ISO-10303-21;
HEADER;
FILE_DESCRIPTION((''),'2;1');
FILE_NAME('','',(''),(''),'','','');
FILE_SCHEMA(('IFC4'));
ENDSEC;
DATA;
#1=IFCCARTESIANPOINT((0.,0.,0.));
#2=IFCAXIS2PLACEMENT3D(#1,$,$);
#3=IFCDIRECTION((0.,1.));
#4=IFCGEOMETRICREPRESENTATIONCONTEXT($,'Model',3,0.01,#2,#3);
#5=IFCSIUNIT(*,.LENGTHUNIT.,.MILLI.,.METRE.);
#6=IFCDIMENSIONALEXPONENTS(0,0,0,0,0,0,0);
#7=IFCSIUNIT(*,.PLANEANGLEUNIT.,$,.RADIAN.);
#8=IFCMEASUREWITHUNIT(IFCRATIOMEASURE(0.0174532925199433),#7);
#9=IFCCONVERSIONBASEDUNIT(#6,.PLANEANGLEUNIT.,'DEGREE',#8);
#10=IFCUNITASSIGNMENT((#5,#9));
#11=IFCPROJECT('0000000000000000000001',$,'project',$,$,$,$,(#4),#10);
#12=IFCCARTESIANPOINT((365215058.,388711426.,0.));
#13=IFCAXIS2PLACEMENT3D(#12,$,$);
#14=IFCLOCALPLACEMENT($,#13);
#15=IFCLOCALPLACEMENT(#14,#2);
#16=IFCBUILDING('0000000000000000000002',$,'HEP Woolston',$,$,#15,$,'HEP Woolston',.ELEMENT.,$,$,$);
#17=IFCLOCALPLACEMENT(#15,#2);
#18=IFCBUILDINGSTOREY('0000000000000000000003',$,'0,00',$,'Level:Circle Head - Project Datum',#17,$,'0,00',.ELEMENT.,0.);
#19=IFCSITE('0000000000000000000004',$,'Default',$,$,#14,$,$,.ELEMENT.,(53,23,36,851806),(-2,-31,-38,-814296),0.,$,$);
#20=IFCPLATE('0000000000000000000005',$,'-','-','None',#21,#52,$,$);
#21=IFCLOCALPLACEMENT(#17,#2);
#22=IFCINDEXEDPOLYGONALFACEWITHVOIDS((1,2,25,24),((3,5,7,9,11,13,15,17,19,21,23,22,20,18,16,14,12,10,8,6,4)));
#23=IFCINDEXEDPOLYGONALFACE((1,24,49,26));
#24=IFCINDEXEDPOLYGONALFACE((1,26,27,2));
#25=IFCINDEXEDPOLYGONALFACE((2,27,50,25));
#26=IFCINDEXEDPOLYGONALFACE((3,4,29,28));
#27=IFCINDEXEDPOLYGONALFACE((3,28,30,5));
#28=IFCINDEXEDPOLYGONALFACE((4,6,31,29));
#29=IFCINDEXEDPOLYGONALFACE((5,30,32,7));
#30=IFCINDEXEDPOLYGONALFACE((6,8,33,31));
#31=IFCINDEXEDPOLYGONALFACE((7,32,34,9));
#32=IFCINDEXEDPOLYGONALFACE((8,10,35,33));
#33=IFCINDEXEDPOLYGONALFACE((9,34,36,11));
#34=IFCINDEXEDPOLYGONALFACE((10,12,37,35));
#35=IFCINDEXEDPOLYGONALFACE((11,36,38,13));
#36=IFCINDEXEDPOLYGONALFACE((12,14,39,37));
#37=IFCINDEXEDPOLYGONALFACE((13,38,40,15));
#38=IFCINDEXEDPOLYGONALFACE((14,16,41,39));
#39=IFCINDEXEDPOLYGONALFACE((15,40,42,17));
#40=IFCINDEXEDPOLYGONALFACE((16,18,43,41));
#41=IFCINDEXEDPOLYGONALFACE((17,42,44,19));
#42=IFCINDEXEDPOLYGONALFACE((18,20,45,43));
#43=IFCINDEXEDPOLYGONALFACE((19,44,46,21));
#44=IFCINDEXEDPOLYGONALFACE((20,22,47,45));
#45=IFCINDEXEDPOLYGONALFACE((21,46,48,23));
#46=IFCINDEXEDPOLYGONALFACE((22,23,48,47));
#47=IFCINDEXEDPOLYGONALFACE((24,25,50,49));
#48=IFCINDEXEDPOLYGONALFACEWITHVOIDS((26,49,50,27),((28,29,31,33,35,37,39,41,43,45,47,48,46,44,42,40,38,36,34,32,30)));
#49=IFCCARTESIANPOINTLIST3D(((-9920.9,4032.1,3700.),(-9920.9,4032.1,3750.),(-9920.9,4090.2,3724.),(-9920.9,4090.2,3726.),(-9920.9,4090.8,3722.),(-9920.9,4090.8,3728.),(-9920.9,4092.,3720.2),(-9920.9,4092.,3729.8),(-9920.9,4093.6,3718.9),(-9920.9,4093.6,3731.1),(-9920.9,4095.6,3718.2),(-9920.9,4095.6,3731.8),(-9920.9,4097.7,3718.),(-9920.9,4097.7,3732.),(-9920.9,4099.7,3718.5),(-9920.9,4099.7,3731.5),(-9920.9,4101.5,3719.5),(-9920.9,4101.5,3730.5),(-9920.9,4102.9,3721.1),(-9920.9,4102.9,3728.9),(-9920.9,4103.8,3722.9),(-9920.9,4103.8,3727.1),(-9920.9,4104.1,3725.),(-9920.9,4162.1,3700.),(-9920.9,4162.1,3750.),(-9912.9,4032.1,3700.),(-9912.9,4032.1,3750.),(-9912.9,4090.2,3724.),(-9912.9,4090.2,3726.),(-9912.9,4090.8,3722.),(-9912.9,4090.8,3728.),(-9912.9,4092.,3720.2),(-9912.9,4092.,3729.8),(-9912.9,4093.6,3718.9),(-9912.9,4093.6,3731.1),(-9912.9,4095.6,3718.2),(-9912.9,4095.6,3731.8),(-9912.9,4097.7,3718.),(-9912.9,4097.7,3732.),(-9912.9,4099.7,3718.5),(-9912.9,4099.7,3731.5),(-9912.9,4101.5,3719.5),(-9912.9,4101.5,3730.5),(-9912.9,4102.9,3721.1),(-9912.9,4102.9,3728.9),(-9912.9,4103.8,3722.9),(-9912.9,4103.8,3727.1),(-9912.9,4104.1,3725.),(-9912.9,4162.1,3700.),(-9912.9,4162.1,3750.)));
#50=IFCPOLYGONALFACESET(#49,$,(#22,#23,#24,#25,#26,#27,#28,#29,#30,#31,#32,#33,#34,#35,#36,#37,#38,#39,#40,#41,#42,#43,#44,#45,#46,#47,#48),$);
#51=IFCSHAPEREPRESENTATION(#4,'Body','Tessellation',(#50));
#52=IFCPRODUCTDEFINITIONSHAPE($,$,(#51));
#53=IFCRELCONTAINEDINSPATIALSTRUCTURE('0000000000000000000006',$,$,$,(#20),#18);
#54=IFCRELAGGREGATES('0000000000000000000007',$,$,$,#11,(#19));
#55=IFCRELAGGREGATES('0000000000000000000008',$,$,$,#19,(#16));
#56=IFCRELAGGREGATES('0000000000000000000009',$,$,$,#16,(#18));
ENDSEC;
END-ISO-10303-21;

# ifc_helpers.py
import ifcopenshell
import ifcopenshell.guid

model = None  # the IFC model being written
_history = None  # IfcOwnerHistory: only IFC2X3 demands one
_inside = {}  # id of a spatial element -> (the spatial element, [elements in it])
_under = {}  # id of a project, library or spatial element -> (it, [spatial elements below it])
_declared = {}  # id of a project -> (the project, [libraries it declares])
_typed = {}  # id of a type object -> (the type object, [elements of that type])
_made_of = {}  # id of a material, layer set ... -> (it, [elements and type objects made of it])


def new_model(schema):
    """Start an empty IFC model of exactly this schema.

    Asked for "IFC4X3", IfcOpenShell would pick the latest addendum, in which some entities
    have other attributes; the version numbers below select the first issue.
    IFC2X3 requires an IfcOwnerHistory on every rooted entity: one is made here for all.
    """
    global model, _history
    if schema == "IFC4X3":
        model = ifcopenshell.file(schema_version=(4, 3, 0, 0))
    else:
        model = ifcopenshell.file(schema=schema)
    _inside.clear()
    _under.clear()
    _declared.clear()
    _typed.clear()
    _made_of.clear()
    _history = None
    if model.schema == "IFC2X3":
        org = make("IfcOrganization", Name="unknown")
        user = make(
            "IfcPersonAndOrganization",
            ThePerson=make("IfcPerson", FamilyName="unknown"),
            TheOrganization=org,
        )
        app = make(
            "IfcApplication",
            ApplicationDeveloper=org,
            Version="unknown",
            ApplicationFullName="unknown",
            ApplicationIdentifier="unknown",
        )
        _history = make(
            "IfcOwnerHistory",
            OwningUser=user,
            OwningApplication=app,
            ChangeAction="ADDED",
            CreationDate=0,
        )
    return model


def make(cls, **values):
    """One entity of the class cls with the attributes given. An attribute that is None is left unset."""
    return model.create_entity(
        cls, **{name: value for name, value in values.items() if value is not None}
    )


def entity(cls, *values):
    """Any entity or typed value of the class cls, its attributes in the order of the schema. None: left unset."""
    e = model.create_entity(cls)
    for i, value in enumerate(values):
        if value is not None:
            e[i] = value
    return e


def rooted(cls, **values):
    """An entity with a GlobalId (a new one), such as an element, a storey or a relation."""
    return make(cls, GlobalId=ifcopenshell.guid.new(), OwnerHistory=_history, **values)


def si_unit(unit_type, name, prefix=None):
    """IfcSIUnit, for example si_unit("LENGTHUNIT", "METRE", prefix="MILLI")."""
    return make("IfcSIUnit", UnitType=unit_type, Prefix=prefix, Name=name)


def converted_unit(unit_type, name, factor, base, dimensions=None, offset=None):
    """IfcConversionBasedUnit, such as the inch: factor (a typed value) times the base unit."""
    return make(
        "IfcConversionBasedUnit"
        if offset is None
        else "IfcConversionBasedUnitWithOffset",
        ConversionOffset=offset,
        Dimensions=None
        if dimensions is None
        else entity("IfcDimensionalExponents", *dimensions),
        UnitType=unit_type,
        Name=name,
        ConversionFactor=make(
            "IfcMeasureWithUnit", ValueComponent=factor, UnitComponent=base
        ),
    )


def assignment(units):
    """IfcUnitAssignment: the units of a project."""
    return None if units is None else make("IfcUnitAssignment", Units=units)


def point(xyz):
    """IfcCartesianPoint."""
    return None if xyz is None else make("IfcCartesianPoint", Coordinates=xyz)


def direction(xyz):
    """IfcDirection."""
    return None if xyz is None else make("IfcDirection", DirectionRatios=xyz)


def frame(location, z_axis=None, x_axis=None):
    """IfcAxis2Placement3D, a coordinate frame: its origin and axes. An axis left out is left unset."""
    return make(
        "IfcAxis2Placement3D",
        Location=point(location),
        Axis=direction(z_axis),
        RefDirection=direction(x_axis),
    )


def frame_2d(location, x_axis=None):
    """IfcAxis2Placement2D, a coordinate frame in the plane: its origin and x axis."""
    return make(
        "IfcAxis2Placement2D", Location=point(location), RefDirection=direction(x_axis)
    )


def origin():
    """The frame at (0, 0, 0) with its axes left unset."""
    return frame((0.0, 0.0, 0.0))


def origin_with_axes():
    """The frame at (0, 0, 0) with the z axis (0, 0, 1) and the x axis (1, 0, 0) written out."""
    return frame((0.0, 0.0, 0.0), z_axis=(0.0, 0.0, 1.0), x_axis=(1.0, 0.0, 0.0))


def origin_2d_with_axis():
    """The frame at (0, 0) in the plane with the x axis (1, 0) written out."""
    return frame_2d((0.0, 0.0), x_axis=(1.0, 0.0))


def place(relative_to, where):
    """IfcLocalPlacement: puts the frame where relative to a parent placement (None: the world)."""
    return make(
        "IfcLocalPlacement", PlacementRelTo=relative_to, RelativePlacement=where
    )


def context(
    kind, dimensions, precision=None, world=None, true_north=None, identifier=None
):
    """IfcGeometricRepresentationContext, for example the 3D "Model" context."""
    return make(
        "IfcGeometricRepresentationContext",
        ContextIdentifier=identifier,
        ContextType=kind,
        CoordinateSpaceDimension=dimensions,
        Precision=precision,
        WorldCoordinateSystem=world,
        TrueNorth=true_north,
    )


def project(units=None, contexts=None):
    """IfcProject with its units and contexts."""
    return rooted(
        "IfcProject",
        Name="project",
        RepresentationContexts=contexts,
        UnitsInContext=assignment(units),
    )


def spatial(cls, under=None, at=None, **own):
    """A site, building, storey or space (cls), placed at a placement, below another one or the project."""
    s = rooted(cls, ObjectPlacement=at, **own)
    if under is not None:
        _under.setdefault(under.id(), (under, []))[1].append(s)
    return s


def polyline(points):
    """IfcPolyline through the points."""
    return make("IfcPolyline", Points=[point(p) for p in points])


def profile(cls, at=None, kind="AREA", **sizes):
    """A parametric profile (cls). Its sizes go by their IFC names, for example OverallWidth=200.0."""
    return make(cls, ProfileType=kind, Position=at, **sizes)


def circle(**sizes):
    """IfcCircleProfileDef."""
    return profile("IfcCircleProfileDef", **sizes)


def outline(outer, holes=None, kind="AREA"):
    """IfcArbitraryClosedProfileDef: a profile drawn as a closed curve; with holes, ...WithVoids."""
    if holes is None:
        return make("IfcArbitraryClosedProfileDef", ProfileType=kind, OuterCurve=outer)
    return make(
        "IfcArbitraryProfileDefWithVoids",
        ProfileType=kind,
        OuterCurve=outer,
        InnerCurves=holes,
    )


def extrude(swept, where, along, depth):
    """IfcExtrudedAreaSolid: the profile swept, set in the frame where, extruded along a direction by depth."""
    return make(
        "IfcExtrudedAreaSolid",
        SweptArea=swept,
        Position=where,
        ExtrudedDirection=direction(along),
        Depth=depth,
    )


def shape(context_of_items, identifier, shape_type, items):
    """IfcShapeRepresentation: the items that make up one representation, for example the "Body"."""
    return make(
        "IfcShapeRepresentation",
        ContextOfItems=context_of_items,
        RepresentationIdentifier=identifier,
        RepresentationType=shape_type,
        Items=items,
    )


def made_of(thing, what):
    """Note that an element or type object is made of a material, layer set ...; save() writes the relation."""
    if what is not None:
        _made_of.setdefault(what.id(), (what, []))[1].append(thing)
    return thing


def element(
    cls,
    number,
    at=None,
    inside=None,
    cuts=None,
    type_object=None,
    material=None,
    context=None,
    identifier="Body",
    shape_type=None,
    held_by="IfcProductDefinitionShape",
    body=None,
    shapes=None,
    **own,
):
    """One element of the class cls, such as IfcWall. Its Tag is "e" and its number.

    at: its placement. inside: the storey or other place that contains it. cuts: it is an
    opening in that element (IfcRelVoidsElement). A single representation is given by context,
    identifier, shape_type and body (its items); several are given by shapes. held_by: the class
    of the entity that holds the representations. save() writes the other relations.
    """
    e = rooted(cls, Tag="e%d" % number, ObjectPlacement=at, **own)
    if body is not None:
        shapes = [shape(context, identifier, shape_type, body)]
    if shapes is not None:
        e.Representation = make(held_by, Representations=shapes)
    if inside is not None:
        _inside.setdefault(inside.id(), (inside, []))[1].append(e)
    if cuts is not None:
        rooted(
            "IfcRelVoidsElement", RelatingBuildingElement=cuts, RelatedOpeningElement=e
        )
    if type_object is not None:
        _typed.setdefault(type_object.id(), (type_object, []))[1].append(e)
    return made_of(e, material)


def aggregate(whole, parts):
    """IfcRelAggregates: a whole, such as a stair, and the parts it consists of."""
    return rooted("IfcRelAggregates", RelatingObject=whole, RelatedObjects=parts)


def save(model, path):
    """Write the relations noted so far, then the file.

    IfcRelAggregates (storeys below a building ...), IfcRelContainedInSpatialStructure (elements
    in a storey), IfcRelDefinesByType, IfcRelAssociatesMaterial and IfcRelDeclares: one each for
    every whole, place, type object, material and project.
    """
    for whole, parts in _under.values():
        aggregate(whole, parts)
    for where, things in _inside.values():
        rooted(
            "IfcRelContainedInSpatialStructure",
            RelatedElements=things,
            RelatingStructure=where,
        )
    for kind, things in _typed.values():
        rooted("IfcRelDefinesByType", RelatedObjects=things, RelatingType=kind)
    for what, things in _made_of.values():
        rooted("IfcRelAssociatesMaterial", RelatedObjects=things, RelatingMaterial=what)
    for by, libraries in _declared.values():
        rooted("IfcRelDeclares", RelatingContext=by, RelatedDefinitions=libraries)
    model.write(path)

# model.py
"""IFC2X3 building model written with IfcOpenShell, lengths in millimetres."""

from ifc_helpers import new_model, entity, si_unit, converted_unit, direction, frame, origin, origin_with_axes, origin_2d_with_axis, place, context, project, spatial, polyline, circle, outline, extrude, element, save


model = new_model("IFC2X3")

# Units and contexts
model_context = context("Model", 3, precision=0.01, world=origin(), true_north=direction((0.0, 1.0)))
ifc_project = project(units=[si_unit("LENGTHUNIT", "METRE", prefix="MILLI"), converted_unit("PLANEANGLEUNIT", "DEGREE", entity("IfcRatioMeasure", 0.0174532925199433), si_unit("PLANEANGLEUNIT", "RADIAN"), dimensions=[0, 0, 0, 0, 0, 0, 0])], contexts=[model_context])

# Site, building, storey
site_placement = place(None, frame((365215058.0, 388711426.0, 0.0)))
site = spatial("IfcSite", under=ifc_project, at=site_placement, Name="Default", CompositionType="ELEMENT", RefLatitude=(53, 23, 36, 851806), RefLongitude=(-2, -31, -38, -814296), RefElevation=0.0)
building_placement = place(site_placement, origin())
building = spatial("IfcBuilding", under=site, at=building_placement, Name="HEP Woolston", LongName="HEP Woolston", CompositionType="ELEMENT")
storey_placement = place(building_placement, origin())
storey = spatial("IfcBuildingStorey", under=building, at=storey_placement, Name="0,00", ObjectType="Level:Circle Head - Project Datum", LongName="0,00", CompositionType="ELEMENT", Elevation=0.0)

# Plate, opening
plate_1_placement = place(storey_placement, frame((-9920.9, 4032.1, 3750.0), z_axis=(1.0, 0.0, 0.0), x_axis=(0.0, 1.0, 0.0)))
plate_1 = element("IfcPlate", 1, at=plate_1_placement, inside=storey, Name="-", Description="-", ObjectType="None", context=model_context, shape_type="SweptSolid", body=[
    extrude(outline(polyline([(0.0, -50.0), (130.0, -50.0), (130.0, 0.0), (0.0, 0.0), (0.0, -50.0)])), origin_with_axes(), (0.0, 0.0, 1.0), 8.0),
])
opening_1_placement = place(plate_1_placement, frame((65.0, -25.0, 8.5), z_axis=(0.0, 0.0, -1.0), x_axis=(1.0, 0.0, 0.0)))
element("IfcOpeningElement", 2, at=opening_1_placement, cuts=plate_1, ObjectType="Opening", context=model_context, shape_type="SweptSolid", body=[
    extrude(circle(Radius=7.0, at=origin_2d_with_axis()), origin(), (0.0, 0.0, 1.0), 9.0),
])

save(model, "model.ifc")
